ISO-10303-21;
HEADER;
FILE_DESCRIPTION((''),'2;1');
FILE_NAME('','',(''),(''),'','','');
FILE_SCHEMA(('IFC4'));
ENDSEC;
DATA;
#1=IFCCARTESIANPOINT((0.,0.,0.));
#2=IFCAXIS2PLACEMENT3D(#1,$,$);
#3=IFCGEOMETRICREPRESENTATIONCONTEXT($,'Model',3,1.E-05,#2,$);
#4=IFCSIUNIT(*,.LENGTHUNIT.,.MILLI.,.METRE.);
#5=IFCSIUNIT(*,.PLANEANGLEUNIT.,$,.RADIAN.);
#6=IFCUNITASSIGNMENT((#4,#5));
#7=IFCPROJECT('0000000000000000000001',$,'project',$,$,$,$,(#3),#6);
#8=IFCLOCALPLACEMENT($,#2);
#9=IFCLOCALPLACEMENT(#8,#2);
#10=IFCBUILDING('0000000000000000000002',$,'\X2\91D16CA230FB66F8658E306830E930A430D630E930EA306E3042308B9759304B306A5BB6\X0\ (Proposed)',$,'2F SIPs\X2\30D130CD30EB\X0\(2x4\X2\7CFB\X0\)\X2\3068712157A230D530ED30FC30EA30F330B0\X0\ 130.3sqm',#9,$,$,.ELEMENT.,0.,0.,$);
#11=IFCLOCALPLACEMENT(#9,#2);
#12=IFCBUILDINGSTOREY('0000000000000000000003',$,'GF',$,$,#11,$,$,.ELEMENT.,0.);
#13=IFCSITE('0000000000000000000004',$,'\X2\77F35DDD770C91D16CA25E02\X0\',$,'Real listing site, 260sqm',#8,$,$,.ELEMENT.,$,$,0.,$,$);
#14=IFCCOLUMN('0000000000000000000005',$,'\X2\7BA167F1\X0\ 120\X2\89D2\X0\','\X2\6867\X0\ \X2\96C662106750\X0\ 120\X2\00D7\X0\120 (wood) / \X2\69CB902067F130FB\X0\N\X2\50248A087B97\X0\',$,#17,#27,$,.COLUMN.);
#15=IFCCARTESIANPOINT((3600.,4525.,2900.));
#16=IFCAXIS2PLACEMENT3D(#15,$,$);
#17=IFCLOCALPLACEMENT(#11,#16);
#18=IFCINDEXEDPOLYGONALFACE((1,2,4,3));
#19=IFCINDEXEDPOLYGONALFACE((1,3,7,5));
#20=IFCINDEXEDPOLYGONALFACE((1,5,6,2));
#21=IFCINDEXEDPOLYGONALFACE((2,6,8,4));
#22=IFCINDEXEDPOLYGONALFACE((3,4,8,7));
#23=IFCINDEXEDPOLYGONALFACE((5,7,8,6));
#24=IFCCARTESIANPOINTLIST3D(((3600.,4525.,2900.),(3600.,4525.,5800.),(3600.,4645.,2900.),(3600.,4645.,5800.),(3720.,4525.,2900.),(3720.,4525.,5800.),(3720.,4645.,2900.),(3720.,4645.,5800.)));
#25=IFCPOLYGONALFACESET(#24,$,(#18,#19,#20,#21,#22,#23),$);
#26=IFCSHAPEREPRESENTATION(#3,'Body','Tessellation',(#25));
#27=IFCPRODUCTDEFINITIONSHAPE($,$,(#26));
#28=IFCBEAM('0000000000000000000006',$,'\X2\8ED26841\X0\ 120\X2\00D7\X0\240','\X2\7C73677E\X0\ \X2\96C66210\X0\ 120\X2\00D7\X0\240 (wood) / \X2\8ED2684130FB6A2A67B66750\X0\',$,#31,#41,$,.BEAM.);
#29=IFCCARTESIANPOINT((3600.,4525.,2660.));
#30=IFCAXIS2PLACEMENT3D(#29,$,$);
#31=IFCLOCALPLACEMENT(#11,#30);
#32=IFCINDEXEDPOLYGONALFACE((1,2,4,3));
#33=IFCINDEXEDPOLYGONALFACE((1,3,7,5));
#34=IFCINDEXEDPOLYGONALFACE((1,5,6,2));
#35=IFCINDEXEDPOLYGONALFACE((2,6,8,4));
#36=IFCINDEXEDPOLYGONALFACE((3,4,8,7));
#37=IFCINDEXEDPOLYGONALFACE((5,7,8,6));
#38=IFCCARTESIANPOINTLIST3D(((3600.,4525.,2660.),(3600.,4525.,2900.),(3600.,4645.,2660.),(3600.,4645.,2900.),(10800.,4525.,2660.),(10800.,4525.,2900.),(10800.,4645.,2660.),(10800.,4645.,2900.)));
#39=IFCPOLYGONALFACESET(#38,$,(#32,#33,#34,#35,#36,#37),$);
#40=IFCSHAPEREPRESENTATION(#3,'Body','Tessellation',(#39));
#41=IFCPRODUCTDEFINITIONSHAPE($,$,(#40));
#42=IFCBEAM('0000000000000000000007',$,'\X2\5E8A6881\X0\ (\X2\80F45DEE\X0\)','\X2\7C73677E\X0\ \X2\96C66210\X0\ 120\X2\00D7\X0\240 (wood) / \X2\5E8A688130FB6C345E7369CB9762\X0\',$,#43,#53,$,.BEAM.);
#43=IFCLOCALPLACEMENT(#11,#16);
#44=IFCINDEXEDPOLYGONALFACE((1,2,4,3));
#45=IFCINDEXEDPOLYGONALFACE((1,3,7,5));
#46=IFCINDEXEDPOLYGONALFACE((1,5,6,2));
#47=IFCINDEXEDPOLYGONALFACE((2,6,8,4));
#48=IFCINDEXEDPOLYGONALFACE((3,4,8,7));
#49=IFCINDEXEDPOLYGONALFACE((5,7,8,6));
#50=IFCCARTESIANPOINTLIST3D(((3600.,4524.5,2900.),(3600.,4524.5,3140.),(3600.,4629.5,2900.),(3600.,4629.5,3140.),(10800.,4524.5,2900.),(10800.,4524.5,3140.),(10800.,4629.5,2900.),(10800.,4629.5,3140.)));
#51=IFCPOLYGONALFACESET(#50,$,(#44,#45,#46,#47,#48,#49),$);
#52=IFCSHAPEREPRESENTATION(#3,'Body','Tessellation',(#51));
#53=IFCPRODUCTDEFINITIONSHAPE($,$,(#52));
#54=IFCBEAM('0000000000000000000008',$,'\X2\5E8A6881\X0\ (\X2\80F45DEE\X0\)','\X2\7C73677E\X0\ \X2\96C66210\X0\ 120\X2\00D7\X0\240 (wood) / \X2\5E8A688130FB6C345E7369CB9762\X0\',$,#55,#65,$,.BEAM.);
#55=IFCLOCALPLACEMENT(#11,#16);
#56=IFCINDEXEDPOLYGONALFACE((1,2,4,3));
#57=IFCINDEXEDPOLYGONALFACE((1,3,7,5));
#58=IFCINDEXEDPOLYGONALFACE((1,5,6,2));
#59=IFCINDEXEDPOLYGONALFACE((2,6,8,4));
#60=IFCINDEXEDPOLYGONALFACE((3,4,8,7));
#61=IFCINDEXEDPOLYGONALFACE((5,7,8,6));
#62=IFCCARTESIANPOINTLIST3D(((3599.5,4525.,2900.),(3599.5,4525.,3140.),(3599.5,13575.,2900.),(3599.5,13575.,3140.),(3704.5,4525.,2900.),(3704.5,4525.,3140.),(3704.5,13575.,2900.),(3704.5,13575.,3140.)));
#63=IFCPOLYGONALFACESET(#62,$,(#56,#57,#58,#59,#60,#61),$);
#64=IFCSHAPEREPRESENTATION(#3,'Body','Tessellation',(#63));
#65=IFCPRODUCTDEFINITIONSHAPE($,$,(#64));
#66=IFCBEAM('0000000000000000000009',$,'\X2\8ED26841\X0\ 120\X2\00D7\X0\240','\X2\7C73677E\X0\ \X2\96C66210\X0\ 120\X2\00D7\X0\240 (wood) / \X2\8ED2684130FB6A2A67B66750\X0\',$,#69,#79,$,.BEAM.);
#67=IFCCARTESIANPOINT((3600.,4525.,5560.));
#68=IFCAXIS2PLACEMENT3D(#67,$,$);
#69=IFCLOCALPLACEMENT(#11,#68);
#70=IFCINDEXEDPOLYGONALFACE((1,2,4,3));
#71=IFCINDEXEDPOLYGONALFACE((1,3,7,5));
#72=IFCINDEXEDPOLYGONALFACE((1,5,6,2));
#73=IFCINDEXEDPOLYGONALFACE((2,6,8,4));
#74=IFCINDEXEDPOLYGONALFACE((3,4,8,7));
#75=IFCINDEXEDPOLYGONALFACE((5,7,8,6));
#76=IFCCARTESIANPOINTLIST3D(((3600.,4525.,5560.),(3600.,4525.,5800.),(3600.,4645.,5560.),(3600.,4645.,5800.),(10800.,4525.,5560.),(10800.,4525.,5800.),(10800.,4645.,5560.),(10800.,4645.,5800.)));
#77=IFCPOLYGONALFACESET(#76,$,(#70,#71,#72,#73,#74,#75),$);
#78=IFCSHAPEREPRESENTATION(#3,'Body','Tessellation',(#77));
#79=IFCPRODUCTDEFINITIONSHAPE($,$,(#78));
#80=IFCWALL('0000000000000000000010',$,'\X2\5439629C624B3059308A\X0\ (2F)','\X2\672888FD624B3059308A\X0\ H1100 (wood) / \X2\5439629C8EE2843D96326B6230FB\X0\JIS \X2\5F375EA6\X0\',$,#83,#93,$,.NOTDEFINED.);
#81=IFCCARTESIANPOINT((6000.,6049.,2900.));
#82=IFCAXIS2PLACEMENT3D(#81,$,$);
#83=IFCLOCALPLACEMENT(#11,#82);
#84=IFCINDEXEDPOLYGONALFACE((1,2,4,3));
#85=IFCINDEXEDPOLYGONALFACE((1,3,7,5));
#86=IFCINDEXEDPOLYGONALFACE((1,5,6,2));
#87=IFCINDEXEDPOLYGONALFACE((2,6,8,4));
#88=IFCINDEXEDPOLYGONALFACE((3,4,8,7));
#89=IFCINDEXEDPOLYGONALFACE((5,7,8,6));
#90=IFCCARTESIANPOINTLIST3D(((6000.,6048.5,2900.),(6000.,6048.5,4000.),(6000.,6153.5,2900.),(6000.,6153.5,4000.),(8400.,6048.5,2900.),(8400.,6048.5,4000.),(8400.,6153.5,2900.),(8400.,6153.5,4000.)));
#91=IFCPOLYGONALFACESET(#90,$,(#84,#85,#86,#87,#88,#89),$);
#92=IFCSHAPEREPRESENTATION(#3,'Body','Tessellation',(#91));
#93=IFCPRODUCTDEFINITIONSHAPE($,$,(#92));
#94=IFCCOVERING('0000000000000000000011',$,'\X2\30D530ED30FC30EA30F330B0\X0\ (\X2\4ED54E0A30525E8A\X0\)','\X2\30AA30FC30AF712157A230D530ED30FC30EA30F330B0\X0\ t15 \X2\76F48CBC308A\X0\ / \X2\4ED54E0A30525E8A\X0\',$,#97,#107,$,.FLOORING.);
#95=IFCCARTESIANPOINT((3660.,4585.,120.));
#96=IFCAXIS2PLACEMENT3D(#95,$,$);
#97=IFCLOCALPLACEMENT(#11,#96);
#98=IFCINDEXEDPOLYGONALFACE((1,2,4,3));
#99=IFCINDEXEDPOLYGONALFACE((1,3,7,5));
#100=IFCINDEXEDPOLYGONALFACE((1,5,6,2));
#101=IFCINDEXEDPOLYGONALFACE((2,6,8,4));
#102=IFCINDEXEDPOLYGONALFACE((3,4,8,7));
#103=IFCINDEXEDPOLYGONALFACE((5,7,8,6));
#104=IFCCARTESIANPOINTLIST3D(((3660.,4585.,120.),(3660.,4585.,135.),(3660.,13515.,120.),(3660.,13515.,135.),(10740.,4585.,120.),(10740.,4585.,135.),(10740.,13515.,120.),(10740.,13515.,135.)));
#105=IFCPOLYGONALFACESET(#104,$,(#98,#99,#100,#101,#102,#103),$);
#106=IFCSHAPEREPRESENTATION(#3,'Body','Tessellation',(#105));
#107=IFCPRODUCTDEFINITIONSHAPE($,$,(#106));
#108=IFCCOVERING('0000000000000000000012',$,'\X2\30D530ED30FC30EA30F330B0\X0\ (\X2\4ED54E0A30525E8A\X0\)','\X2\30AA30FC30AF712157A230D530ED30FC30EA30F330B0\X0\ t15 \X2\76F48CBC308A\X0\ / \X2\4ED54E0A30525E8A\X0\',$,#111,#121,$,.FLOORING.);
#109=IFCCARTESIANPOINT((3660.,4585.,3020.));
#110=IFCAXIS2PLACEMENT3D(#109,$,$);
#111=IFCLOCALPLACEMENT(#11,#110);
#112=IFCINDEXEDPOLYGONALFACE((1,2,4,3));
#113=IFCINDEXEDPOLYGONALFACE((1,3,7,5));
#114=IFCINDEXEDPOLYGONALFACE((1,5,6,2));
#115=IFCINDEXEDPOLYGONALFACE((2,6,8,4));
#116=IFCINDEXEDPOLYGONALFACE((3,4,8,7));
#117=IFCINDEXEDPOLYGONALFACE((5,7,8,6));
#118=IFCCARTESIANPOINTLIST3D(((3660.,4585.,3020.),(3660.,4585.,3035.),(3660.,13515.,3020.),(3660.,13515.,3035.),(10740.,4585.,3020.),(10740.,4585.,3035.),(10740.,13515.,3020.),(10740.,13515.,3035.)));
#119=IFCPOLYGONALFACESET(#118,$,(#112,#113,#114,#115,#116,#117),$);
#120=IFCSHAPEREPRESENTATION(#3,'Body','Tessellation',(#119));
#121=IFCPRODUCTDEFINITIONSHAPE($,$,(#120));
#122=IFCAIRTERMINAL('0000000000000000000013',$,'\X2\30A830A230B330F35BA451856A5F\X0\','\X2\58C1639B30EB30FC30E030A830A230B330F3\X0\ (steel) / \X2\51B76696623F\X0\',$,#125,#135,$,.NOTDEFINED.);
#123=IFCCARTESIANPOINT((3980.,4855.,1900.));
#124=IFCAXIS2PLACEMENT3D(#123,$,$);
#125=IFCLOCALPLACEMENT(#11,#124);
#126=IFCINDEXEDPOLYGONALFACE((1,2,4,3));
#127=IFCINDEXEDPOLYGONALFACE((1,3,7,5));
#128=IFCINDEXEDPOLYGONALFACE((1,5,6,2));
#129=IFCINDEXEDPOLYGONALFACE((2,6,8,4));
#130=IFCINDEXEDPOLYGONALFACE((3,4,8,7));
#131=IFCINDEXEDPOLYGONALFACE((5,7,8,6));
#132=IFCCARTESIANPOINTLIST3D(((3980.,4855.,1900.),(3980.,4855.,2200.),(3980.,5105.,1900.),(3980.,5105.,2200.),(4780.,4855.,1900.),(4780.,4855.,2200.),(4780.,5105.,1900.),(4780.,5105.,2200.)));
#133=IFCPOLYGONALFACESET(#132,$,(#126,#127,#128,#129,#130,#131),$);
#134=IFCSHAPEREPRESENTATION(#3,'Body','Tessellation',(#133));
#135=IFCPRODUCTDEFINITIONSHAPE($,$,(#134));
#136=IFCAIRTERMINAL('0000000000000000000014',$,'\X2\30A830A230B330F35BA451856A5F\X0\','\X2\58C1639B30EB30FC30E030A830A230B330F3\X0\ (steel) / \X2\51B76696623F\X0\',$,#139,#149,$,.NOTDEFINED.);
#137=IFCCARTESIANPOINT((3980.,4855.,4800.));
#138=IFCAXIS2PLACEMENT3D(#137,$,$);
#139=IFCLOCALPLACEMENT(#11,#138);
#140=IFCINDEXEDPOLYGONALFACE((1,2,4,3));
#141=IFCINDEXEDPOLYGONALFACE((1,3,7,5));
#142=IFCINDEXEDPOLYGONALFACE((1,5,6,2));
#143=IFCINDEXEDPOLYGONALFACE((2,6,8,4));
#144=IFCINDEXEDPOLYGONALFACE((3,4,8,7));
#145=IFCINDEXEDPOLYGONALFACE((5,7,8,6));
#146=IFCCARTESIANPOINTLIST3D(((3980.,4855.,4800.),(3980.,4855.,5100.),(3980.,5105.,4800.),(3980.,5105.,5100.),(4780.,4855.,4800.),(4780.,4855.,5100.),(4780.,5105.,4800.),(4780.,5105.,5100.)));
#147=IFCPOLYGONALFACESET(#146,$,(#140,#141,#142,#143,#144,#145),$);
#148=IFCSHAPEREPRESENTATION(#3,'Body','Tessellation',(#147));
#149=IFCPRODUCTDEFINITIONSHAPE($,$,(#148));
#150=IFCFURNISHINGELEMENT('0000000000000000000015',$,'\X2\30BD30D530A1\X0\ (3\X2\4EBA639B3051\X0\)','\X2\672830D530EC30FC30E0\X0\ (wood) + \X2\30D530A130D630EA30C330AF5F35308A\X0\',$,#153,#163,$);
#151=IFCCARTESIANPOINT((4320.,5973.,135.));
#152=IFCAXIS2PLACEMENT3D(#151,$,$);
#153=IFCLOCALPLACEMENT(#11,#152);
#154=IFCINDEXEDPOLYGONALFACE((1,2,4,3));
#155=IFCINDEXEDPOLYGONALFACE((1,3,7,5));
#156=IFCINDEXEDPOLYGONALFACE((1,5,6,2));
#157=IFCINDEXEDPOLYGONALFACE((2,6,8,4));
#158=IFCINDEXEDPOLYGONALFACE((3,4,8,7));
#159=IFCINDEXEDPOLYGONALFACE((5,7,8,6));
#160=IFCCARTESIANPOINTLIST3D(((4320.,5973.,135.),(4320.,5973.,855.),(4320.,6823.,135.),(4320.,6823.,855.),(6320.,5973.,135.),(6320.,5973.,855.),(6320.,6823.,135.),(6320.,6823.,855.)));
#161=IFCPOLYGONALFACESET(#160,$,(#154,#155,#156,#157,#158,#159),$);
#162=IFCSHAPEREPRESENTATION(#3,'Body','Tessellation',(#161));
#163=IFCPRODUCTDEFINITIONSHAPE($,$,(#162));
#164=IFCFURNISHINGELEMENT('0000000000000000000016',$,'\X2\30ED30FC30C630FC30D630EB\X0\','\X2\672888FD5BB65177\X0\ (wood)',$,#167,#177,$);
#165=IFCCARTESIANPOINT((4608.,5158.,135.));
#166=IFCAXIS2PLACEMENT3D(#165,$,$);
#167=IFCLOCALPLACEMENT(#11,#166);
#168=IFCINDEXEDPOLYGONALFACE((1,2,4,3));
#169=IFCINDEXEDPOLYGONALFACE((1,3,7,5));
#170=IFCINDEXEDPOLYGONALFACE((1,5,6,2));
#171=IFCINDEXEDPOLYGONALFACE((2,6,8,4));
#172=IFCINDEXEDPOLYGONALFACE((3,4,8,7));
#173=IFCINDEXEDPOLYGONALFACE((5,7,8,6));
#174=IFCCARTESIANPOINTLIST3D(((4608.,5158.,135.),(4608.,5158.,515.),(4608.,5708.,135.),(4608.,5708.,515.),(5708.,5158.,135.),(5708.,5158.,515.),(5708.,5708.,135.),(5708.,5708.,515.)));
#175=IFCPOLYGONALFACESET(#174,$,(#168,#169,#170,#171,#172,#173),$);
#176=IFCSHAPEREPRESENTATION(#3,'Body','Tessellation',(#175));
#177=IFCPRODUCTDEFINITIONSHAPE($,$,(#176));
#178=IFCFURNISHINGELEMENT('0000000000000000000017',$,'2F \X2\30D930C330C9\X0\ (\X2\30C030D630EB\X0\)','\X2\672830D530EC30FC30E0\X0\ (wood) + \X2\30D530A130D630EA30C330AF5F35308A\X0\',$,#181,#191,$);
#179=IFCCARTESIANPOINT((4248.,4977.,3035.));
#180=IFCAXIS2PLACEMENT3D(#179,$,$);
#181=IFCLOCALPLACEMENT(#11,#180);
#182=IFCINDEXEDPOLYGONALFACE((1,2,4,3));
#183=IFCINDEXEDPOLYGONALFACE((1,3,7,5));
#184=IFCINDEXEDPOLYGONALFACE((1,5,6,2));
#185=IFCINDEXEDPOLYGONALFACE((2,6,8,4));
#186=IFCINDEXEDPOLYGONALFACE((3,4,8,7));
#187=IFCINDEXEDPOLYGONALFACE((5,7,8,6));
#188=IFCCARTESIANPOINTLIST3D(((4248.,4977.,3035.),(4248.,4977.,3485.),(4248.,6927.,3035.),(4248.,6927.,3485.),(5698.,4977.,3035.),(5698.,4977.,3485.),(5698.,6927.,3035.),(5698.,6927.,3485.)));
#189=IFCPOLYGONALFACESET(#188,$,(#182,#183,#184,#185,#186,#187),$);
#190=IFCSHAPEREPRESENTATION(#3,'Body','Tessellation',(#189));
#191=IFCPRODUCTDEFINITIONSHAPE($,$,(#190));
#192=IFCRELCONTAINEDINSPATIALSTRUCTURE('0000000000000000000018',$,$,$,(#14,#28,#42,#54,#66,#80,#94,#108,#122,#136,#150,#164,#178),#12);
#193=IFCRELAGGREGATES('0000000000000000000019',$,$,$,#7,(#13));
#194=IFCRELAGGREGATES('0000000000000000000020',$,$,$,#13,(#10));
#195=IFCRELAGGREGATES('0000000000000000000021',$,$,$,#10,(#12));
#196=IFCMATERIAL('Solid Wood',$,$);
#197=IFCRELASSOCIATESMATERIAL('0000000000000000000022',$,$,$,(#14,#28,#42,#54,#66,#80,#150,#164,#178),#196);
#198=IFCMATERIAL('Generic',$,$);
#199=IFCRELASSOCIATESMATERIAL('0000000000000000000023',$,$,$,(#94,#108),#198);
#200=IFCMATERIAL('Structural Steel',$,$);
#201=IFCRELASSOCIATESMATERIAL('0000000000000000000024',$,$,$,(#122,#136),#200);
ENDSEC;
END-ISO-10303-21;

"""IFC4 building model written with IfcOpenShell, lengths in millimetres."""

from ifc_helpers import new_model, si_unit, frame, frame_2d, origin, place, context, project, spatial, rectangle, extrude, material, element, save


model = new_model("IFC4")

# Units and contexts
model_context = context("Model", 3, precision=1e-05, world=origin())
ifc_project = project(units=[si_unit("LENGTHUNIT", "METRE", prefix="MILLI"), si_unit("PLANEANGLEUNIT", "RADIAN")], contexts=[model_context])

# Site, building, storey
site_placement = place(None, origin())
site = spatial("IfcSite", under=ifc_project, at=site_placement, Name="石川県金沢市", ObjectType="Real listing site, 260sqm", CompositionType="ELEMENT", RefElevation=0.0)
building_placement = place(site_placement, origin())
building = spatial("IfcBuilding", under=site, at=building_placement, Name="金沢・書斎とライブラリのある静かな家 (Proposed)", ObjectType="2F SIPsパネル(2x4系)と無垢フローリング 130.3sqm", CompositionType="ELEMENT", ElevationOfRefHeight=0.0, ElevationOfTerrain=0.0)
storey_placement = place(building_placement, origin())
storey = spatial("IfcBuildingStorey", under=building, at=storey_placement, Name="GF", CompositionType="ELEMENT", Elevation=0.0)

# Column
ifc_material_1 = material(Name="Solid Wood")
column_placement = place(storey_placement, frame((3600.0, 4525.0, 2900.0)))
element("IfcColumn", 1, at=column_placement, inside=storey, material=ifc_material_1, Name="管柱 120角", Description="桧 集成材 120×120 (wood) / 構造柱・N値計算", PredefinedType="COLUMN", context=model_context, shape_type="SweptSolid", body=[
    extrude(rectangle(XDim=120.0, YDim=120.0, at=frame_2d((60.0, 60.0))), frame((3600.0, 4525.0, 2900.0)), (0.0, 0.0, 1.0), 2900.0),
])

# Beams
beam_1_placement = place(storey_placement, frame((3600.0, 4525.0, 2660.0)))
element("IfcBeam", 2, at=beam_1_placement, inside=storey, material=ifc_material_1, Name="軒桁 120×240", Description="米松 集成 120×240 (wood) / 軒桁・横架材", PredefinedType="BEAM", context=model_context, shape_type="SweptSolid", body=[
    extrude(rectangle(XDim=7200.0, YDim=120.0, at=frame_2d((3600.0, 60.0))), frame((3600.0, 4525.0, 2660.0)), (0.0, 0.0, 1.0), 240.0),
])
beam_2_placement = place(storey_placement, frame((3600.0, 4525.0, 2900.0)))
element("IfcBeam", 3, at=beam_2_placement, inside=storey, material=ifc_material_1, Name="床梁 (胴差)", Description="米松 集成 120×240 (wood) / 床梁・水平構面", PredefinedType="BEAM", context=model_context, shape_type="SweptSolid", body=[
    extrude(rectangle(XDim=7200.0, YDim=105.0, at=frame_2d((3600.0, 52.0))), frame((3600.0, 4525.0, 2900.0)), (0.0, 0.0, 1.0), 240.0),
])
beam_3_placement = place(storey_placement, frame((3600.0, 4525.0, 2900.0)))
element("IfcBeam", 4, at=beam_3_placement, inside=storey, material=ifc_material_1, Name="床梁 (胴差)", Description="米松 集成 120×240 (wood) / 床梁・水平構面", PredefinedType="BEAM", context=model_context, shape_type="SweptSolid", body=[
    extrude(rectangle(XDim=105.0, YDim=9050.0, at=frame_2d((52.0, 4525.0))), frame((3600.0, 4525.0, 2900.0)), (0.0, 0.0, 1.0), 240.0),
])
beam_4_placement = place(storey_placement, frame((3600.0, 4525.0, 5560.0)))
element("IfcBeam", 5, at=beam_4_placement, inside=storey, material=ifc_material_1, Name="軒桁 120×240", Description="米松 集成 120×240 (wood) / 軒桁・横架材", PredefinedType="BEAM", context=model_context, shape_type="SweptSolid", body=[
    extrude(rectangle(XDim=7200.0, YDim=120.0, at=frame_2d((3600.0, 60.0))), frame((3600.0, 4525.0, 5560.0)), (0.0, 0.0, 1.0), 240.0),
])

# Wall
wall_placement = place(storey_placement, frame((6000.0, 6049.0, 2900.0)))
element("IfcWall", 6, at=wall_placement, inside=storey, material=ifc_material_1, Name="吹抜手すり (2F)", Description="木製手すり H1100 (wood) / 吹抜転落防止・JIS 強度", PredefinedType="NOTDEFINED", context=model_context, shape_type="SweptSolid", body=[
    extrude(rectangle(XDim=2400.0, YDim=105.0, at=frame_2d((1200.0, 52.0))), frame((6000.0, 6049.0, 2900.0)), (0.0, 0.0, 1.0), 1100.0),
])

# Coverings
ifc_material_2 = material(Name="Generic")
covering_1_placement = place(storey_placement, frame((3660.0, 4585.0, 120.0)))
element("IfcCovering", 7, at=covering_1_placement, inside=storey, material=ifc_material_2, Name="フローリング (仕上げ床)", Description="オーク無垢フローリング t15 直貼り / 仕上げ床", PredefinedType="FLOORING", context=model_context, shape_type="SweptSolid", body=[
    extrude(rectangle(XDim=7080.0, YDim=8930.0, at=frame_2d((3540.0, 4465.0))), frame((3660.0, 4585.0, 120.0)), (0.0, 0.0, 1.0), 15.0),
])
covering_2_placement = place(storey_placement, frame((3660.0, 4585.0, 3020.0)))
element("IfcCovering", 8, at=covering_2_placement, inside=storey, material=ifc_material_2, Name="フローリング (仕上げ床)", Description="オーク無垢フローリング t15 直貼り / 仕上げ床", PredefinedType="FLOORING", context=model_context, shape_type="SweptSolid", body=[
    extrude(rectangle(XDim=7080.0, YDim=8930.0, at=frame_2d((3540.0, 4465.0))), frame((3660.0, 4585.0, 3020.0)), (0.0, 0.0, 1.0), 15.0),
])

# Air terminals
ifc_material_3 = material(Name="Structural Steel")
air_terminal_1_placement = place(storey_placement, frame((3980.0, 4855.0, 1900.0)))
element("IfcAirTerminal", 9, at=air_terminal_1_placement, inside=storey, material=ifc_material_3, Name="エアコン室内機", Description="壁掛ルームエアコン (steel) / 冷暖房", PredefinedType="NOTDEFINED", context=model_context, shape_type="SweptSolid", body=[
    extrude(rectangle(XDim=800.0, YDim=250.0, at=frame_2d((400.0, 125.0))), frame((3980.0, 4855.0, 1900.0)), (0.0, 0.0, 1.0), 300.0),
])
air_terminal_2_placement = place(storey_placement, frame((3980.0, 4855.0, 4800.0)))
element("IfcAirTerminal", 10, at=air_terminal_2_placement, inside=storey, material=ifc_material_3, Name="エアコン室内機", Description="壁掛ルームエアコン (steel) / 冷暖房", PredefinedType="NOTDEFINED", context=model_context, shape_type="SweptSolid", body=[
    extrude(rectangle(XDim=800.0, YDim=250.0, at=frame_2d((400.0, 125.0))), frame((3980.0, 4855.0, 4800.0)), (0.0, 0.0, 1.0), 300.0),
])

# Furnishing elements
furnishing_1_placement = place(storey_placement, frame((4320.0, 5973.0, 135.0)))
element("IfcFurnishingElement", 11, at=furnishing_1_placement, inside=storey, material=ifc_material_1, Name="ソファ (3人掛け)", Description="木フレーム (wood) + ファブリック張り", context=model_context, shape_type="SweptSolid", body=[
    extrude(rectangle(XDim=2000.0, YDim=850.0, at=frame_2d((1000.0, 425.0))), frame((4320.0, 5973.0, 135.0)), (0.0, 0.0, 1.0), 720.0),
])
furnishing_2_placement = place(storey_placement, frame((4608.0, 5158.0, 135.0)))
element("IfcFurnishingElement", 12, at=furnishing_2_placement, inside=storey, material=ifc_material_1, Name="ローテーブル", Description="木製家具 (wood)", context=model_context, shape_type="SweptSolid", body=[
    extrude(rectangle(XDim=1100.0, YDim=550.0, at=frame_2d((550.0, 275.0))), frame((4608.0, 5158.0, 135.0)), (0.0, 0.0, 1.0), 380.0),
])
furnishing_3_placement = place(storey_placement, frame((4248.0, 4977.0, 3035.0)))
element("IfcFurnishingElement", 13, at=furnishing_3_placement, inside=storey, material=ifc_material_1, Name="2F ベッド (ダブル)", Description="木フレーム (wood) + ファブリック張り", context=model_context, shape_type="SweptSolid", body=[
    extrude(rectangle(XDim=1450.0, YDim=1950.0, at=frame_2d((725.0, 975.0))), frame((4248.0, 4977.0, 3035.0)), (0.0, 0.0, 1.0), 450.0),
])

save(model, "model.ifc")
